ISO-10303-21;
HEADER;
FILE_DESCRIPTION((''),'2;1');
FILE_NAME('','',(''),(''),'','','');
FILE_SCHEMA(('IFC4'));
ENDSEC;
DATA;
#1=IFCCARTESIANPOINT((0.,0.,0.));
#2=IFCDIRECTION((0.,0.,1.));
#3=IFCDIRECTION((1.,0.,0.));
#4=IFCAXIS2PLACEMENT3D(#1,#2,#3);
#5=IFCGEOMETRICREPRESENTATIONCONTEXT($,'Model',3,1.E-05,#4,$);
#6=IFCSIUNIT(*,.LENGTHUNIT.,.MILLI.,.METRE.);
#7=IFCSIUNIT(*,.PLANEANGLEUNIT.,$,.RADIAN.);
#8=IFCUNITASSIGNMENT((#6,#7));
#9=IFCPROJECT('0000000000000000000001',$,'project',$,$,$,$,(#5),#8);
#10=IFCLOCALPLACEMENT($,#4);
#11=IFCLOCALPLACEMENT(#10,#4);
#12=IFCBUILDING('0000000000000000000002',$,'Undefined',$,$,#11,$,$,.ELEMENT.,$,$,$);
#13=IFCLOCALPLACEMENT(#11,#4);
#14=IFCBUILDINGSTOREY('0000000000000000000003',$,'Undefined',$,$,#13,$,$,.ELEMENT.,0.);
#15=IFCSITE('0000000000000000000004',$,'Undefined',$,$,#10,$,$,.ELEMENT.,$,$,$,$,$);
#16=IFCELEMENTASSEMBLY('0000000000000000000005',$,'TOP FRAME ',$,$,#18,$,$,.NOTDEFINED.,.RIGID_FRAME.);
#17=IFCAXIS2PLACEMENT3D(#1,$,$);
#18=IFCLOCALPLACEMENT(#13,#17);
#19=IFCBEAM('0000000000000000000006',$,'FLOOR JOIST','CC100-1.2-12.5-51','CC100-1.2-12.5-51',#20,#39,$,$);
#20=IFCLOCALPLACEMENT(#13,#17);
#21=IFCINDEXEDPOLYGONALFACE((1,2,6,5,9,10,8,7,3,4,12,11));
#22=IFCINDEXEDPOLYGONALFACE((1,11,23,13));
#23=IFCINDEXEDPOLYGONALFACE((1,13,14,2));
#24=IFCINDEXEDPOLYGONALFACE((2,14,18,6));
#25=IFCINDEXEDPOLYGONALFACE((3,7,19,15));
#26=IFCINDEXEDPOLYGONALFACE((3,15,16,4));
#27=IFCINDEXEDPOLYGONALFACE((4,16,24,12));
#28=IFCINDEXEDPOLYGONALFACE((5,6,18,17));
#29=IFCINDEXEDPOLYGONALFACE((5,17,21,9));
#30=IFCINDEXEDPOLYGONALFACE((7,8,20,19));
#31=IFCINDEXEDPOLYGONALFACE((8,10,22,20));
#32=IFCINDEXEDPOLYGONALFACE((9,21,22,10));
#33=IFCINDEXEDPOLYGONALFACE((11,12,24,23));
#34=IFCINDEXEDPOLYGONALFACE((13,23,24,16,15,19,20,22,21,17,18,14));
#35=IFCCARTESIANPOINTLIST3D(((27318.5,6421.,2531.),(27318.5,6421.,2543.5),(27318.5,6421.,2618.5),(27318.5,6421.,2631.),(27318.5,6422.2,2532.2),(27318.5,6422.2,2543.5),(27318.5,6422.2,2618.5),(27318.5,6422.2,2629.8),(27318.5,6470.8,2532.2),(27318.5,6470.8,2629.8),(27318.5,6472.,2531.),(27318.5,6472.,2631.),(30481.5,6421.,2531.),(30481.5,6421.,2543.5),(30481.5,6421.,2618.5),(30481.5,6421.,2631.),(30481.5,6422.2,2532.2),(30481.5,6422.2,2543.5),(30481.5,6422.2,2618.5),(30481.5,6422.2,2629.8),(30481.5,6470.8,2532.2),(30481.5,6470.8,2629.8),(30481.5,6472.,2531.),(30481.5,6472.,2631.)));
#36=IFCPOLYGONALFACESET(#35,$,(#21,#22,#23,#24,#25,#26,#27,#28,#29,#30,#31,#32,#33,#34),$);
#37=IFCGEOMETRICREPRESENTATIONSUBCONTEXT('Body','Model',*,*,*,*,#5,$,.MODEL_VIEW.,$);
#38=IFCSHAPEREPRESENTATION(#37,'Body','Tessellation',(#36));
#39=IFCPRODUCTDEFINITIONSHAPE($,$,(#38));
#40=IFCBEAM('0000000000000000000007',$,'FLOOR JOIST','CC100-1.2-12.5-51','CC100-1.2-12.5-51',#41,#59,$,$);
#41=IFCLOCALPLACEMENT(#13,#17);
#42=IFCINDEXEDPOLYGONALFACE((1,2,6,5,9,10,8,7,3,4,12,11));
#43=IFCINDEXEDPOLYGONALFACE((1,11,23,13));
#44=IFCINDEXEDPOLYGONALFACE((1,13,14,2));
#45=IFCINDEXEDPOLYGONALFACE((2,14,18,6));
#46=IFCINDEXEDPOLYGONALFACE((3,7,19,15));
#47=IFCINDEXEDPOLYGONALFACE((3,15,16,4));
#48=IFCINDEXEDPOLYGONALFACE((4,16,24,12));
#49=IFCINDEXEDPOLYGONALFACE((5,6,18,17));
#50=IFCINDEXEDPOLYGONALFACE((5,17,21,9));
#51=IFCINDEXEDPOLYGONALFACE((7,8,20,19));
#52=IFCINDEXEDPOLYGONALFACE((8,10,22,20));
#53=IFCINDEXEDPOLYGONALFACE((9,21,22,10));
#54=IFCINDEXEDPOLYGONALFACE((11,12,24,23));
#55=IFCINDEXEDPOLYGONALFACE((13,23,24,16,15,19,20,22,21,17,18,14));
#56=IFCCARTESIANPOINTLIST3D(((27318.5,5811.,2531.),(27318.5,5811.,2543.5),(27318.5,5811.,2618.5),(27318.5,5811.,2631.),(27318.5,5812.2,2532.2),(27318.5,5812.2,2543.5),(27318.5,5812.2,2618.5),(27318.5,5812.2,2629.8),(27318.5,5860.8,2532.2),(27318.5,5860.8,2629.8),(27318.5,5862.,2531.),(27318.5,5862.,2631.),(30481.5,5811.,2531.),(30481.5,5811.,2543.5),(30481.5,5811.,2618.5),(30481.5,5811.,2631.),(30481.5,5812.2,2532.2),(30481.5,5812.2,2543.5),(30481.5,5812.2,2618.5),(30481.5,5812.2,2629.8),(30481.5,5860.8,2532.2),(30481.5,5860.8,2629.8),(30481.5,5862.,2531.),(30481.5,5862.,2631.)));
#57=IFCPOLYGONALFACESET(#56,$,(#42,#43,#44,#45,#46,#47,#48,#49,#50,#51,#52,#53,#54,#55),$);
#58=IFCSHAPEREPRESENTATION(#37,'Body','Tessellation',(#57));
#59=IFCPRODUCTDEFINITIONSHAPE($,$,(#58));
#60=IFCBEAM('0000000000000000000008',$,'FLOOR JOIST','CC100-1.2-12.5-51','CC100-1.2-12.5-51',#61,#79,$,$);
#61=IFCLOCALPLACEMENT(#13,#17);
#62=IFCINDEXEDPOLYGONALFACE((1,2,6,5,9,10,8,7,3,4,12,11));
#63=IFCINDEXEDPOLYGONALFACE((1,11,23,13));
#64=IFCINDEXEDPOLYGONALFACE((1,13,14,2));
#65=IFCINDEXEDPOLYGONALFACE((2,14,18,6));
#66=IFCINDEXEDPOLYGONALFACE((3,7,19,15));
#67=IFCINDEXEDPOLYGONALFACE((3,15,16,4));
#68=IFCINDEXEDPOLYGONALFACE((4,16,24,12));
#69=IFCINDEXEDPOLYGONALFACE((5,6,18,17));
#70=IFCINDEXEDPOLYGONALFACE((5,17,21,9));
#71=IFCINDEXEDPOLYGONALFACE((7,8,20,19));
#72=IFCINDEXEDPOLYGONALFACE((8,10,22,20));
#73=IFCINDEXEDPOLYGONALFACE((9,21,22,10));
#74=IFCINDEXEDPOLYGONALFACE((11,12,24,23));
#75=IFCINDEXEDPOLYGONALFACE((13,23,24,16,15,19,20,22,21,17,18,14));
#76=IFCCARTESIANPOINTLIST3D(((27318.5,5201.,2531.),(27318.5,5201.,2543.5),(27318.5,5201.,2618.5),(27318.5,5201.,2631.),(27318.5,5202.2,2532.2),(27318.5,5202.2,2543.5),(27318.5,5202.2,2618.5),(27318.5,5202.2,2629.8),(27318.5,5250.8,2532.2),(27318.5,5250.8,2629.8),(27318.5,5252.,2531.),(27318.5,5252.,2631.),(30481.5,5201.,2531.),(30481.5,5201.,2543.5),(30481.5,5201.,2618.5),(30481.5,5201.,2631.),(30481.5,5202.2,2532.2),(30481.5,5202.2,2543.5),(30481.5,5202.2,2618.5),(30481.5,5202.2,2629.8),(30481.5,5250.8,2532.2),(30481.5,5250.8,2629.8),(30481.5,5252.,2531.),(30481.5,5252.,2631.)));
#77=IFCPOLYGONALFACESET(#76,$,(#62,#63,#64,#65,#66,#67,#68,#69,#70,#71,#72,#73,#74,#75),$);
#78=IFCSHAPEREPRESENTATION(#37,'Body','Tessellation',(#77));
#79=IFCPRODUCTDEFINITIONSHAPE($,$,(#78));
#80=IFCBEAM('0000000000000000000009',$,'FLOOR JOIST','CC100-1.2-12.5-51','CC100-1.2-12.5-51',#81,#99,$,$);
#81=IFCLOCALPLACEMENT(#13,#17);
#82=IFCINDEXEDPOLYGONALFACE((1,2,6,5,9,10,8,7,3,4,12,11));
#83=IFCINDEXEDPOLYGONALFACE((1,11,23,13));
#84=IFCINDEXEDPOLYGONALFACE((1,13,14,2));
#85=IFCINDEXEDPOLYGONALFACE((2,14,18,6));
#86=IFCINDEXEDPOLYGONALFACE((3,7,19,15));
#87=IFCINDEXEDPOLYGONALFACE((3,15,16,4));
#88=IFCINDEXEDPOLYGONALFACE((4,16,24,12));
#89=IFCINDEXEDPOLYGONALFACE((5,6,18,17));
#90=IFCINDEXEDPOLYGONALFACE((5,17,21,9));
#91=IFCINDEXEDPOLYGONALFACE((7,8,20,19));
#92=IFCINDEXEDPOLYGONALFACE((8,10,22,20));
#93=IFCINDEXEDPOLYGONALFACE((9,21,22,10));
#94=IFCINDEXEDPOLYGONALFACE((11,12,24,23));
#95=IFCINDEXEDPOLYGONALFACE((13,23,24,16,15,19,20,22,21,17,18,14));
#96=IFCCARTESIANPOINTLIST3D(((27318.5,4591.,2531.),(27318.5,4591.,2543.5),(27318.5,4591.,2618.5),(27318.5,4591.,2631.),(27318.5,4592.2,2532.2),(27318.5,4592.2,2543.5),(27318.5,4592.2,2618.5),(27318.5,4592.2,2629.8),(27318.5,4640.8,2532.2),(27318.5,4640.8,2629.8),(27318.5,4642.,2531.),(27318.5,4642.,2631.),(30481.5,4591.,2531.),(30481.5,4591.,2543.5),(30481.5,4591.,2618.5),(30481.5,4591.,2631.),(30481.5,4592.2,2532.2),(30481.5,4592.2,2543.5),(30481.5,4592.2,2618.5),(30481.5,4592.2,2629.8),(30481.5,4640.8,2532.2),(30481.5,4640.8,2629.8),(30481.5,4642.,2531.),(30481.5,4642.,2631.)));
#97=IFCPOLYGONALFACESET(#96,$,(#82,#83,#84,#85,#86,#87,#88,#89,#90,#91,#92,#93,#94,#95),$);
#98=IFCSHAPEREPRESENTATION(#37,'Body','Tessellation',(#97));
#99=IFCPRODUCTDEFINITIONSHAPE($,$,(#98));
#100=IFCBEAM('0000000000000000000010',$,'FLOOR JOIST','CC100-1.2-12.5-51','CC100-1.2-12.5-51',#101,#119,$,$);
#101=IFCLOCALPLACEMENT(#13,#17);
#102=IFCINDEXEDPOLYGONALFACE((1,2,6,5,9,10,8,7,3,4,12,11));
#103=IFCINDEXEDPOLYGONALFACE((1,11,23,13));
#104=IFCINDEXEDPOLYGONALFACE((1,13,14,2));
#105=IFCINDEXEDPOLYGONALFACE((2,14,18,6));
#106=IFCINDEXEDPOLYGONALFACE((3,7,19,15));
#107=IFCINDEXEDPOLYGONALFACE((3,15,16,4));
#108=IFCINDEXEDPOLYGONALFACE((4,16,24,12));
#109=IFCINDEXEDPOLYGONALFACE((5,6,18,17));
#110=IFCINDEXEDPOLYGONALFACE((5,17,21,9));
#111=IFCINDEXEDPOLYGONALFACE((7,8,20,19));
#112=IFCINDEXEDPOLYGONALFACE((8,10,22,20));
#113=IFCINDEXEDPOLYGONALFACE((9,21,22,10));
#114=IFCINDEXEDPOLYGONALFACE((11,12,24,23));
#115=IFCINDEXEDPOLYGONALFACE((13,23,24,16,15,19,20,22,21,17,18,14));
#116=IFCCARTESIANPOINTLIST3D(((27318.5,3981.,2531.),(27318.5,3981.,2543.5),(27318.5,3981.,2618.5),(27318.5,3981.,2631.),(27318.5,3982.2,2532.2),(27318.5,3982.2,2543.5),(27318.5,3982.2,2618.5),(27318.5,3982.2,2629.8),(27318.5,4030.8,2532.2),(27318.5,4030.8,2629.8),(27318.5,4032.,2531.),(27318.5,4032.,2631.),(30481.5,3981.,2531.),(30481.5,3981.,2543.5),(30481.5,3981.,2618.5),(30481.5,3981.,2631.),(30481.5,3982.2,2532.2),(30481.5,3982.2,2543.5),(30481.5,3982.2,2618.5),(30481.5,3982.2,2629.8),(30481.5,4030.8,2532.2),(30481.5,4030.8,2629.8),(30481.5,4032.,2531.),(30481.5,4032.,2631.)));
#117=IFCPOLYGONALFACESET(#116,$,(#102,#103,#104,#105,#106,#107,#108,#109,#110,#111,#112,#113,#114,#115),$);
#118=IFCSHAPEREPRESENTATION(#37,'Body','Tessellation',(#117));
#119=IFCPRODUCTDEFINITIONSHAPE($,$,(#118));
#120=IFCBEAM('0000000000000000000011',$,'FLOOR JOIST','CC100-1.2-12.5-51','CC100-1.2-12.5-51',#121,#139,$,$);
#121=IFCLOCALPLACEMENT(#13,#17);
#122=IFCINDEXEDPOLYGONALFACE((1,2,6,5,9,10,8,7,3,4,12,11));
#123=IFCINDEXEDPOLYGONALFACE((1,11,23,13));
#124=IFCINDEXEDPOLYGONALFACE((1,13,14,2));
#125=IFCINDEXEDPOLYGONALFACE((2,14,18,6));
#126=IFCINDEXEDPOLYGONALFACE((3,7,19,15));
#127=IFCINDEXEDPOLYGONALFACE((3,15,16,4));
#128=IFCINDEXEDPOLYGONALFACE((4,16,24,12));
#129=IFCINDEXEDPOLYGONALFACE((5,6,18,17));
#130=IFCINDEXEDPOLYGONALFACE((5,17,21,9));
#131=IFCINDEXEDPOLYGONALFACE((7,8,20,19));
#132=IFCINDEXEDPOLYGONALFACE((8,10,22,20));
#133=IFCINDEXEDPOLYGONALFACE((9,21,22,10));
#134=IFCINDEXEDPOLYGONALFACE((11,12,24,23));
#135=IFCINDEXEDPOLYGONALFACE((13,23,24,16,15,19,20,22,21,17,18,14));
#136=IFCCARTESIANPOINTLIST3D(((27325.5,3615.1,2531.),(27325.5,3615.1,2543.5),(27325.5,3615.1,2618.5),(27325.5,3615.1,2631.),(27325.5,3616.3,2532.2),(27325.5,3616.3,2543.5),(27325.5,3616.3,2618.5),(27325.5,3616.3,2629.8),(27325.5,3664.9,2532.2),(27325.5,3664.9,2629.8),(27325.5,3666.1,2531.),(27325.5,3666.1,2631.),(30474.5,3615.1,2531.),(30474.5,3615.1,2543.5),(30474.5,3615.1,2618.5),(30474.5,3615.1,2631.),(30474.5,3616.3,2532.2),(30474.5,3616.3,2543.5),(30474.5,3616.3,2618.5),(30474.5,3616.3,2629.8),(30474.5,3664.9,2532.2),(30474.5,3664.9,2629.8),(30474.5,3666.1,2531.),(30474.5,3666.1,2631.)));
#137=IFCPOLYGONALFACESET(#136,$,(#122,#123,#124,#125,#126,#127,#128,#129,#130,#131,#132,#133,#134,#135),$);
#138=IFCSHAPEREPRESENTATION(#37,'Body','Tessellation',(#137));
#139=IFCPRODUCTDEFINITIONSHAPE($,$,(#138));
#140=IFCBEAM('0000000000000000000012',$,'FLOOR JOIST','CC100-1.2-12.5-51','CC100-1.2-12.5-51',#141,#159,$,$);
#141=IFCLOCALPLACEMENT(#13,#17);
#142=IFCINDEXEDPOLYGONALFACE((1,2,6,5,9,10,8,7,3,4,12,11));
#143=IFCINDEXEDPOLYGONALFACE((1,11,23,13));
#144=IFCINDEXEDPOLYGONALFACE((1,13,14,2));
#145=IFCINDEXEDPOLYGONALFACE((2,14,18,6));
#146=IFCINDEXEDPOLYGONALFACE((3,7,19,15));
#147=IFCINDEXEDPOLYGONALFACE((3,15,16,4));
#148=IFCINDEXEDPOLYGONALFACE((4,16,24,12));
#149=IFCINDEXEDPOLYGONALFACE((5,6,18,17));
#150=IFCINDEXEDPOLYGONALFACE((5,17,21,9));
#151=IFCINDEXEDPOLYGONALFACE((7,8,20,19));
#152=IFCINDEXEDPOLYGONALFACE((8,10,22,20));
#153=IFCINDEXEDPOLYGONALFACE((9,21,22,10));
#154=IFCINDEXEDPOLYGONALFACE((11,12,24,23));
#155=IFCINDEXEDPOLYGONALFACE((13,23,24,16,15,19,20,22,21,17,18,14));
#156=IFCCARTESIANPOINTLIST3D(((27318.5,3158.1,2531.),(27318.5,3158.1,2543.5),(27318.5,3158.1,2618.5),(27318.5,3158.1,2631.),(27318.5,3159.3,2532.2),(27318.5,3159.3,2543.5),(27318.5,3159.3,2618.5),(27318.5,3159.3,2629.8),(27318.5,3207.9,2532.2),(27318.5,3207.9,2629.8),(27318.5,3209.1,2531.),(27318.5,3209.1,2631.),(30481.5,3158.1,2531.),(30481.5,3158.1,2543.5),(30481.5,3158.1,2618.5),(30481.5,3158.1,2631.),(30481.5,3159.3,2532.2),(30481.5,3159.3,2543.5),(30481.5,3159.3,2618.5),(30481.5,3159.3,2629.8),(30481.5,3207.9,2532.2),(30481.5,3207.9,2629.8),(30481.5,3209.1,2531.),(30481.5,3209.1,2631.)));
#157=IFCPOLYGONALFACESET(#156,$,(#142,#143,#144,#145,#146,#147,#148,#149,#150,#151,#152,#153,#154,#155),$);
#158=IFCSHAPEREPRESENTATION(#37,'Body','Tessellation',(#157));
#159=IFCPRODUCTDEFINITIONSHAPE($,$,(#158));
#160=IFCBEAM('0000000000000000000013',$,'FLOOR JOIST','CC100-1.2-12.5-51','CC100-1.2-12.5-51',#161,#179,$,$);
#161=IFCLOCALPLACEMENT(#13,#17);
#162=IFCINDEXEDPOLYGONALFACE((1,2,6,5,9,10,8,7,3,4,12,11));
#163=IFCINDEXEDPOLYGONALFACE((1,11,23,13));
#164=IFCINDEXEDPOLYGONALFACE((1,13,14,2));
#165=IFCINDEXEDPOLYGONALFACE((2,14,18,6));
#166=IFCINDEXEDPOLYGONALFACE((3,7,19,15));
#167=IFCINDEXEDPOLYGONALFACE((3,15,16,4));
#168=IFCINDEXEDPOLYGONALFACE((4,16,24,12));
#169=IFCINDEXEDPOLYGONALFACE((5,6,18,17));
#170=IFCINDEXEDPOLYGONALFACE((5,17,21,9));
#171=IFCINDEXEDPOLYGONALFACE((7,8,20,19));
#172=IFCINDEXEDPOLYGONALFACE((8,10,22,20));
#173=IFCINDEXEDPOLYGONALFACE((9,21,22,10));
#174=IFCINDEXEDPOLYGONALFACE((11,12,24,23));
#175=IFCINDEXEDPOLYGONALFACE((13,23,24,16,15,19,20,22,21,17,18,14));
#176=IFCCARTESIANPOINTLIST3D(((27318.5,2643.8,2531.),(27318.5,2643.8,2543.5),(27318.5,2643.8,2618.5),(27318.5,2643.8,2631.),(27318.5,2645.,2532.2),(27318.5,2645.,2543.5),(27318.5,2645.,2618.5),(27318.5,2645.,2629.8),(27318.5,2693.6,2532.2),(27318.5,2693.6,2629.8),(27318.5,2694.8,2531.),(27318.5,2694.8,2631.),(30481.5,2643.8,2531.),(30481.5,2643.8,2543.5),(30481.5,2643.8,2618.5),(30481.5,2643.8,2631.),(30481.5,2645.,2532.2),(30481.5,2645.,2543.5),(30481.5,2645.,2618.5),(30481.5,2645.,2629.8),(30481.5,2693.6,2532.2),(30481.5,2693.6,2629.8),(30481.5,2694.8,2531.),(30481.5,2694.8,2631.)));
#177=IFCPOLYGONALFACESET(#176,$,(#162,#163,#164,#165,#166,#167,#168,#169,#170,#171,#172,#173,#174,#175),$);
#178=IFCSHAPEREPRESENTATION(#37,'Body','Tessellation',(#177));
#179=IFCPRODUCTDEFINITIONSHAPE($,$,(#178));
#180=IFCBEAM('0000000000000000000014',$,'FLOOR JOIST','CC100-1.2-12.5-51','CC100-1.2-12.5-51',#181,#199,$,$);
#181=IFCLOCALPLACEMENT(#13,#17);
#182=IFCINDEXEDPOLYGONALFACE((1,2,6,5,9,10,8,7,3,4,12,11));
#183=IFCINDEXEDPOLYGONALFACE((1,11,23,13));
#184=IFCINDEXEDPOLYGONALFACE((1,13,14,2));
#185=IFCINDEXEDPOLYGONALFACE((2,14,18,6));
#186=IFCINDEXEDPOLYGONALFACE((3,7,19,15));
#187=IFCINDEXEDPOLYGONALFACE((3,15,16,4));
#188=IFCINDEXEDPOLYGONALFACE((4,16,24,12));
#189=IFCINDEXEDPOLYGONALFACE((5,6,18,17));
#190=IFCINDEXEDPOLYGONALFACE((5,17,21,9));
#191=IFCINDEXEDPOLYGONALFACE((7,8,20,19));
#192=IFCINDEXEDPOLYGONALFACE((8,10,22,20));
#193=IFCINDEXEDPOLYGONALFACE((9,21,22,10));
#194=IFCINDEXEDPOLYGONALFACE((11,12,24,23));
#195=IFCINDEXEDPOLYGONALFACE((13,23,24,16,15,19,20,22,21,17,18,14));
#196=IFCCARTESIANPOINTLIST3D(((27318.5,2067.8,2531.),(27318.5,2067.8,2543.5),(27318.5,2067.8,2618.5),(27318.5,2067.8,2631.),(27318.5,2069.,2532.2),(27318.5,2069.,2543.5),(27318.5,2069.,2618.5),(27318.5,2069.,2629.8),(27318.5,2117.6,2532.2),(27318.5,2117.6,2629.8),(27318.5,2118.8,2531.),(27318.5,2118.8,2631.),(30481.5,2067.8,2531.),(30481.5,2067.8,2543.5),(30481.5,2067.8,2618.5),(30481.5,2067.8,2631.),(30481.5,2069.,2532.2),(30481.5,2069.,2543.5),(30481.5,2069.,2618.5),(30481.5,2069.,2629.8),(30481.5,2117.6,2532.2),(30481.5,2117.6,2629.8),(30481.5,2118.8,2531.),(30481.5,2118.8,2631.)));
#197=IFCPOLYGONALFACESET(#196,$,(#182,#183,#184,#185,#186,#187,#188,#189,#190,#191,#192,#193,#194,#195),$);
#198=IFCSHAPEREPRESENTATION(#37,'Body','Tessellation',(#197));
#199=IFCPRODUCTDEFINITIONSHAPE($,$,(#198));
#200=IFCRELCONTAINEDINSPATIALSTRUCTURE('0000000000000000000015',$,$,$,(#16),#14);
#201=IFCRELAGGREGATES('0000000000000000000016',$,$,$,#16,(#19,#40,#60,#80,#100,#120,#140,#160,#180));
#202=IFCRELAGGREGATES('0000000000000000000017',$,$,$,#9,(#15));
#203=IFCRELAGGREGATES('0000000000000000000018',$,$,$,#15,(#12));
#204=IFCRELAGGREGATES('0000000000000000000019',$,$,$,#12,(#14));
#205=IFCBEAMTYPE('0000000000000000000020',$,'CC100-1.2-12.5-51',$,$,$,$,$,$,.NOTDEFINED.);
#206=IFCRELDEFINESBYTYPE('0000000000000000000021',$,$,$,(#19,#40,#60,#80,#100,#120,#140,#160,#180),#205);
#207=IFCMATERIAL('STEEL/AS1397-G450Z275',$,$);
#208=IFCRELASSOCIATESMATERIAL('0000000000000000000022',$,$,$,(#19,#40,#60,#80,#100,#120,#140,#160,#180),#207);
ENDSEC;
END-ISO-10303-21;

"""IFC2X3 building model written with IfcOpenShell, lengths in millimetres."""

from ifc_helpers import new_model, si_unit, frame, origin_with_axes, origin_2d_with_axis, place, context, subcontext, project, spatial, c_section, extrude, material, type_object, element, aggregate, save


model = new_model("IFC2X3")

# Units and contexts
model_context = context("Model", 3, precision=1e-05, world=origin_with_axes())
body_context = subcontext(model_context, "Body", "Model", "MODEL_VIEW")
ifc_project = project(units=[si_unit("LENGTHUNIT", "METRE", prefix="MILLI"), si_unit("PLANEANGLEUNIT", "RADIAN")], contexts=[model_context])

# Site, building, storey
site_placement = place(None, origin_with_axes())
site = spatial("IfcSite", under=ifc_project, at=site_placement, Name="Undefined", CompositionType="ELEMENT")
building_placement = place(site_placement, origin_with_axes())
building = spatial("IfcBuilding", under=site, at=building_placement, Name="Undefined", CompositionType="ELEMENT")
storey_placement = place(building_placement, origin_with_axes())
storey = spatial("IfcBuildingStorey", under=building, at=storey_placement, Name="Undefined", CompositionType="ELEMENT", Elevation=0.0)

# Element assembly, beams
assembly_1_placement = place(storey_placement, origin_with_axes())
assembly_1 = element("IfcElementAssembly", 1, at=assembly_1_placement, inside=storey, Name="TOP FRAME ", AssemblyPlace="NOTDEFINED", PredefinedType="RIGID_FRAME")
ifc_material_1 = material(Name="STEEL/AS1397-G450Z275")
beam_type_1 = type_object("IfcBeamType", Name="CC100-1.2-12.5-51", PredefinedType="NOTDEFINED")
beam_1_placement = place(assembly_1_placement, frame((27318.5, 6446.5, 2581.0), z_axis=(0.0, 0.0, 1.0), x_axis=(1.0, 0.0, 0.0)))
beam_1 = element("IfcBeam", 2, at=beam_1_placement, type_object=beam_type_1, material=ifc_material_1, Name="FLOOR JOIST", Description="CC100-1.2-12.5-51", ObjectType="CC100-1.2-12.5-51", context=body_context, shape_type="SweptSolid", body=[
    extrude(c_section(Depth=100.0, Width=51.0, WallThickness=1.2, Girth=12.5, at=origin_2d_with_axis()), frame((3163.0, 0.0, 0.0), z_axis=(-1.0, 0.0, 0.0), x_axis=(0.0, -1.0, 0.0)), (0.0, 0.0, 1.0), 3163.0),
])
beam_2_placement = place(assembly_1_placement, frame((27318.5, 5836.5, 2581.0), z_axis=(0.0, 0.0, 1.0), x_axis=(1.0, 0.0, 0.0)))
beam_2 = element("IfcBeam", 3, at=beam_2_placement, type_object=beam_type_1, material=ifc_material_1, Name="FLOOR JOIST", Description="CC100-1.2-12.5-51", ObjectType="CC100-1.2-12.5-51", context=body_context, shape_type="SweptSolid", body=[
    extrude(c_section(Depth=100.0, Width=51.0, WallThickness=1.2, Girth=12.5, at=origin_2d_with_axis()), frame((3163.0, 0.0, 0.0), z_axis=(-1.0, 0.0, 0.0), x_axis=(0.0, -1.0, 0.0)), (0.0, 0.0, 1.0), 3163.0),
])
beam_3_placement = place(assembly_1_placement, frame((27318.5, 5226.5, 2581.0), z_axis=(0.0, 0.0, 1.0), x_axis=(1.0, 0.0, 0.0)))
beam_3 = element("IfcBeam", 4, at=beam_3_placement, type_object=beam_type_1, material=ifc_material_1, Name="FLOOR JOIST", Description="CC100-1.2-12.5-51", ObjectType="CC100-1.2-12.5-51", context=body_context, shape_type="SweptSolid", body=[
    extrude(c_section(Depth=100.0, Width=51.0, WallThickness=1.2, Girth=12.5, at=origin_2d_with_axis()), frame((3163.0, 0.0, 0.0), z_axis=(-1.0, 0.0, 0.0), x_axis=(0.0, -1.0, 0.0)), (0.0, 0.0, 1.0), 3163.0),
])
beam_4_placement = place(assembly_1_placement, frame((27318.5, 4616.5, 2581.0), z_axis=(0.0, 0.0, 1.0), x_axis=(1.0, 0.0, 0.0)))
beam_4 = element("IfcBeam", 5, at=beam_4_placement, type_object=beam_type_1, material=ifc_material_1, Name="FLOOR JOIST", Description="CC100-1.2-12.5-51", ObjectType="CC100-1.2-12.5-51", context=body_context, shape_type="SweptSolid", body=[
    extrude(c_section(Depth=100.0, Width=51.0, WallThickness=1.2, Girth=12.5, at=origin_2d_with_axis()), frame((3163.0, 0.0, 0.0), z_axis=(-1.0, 0.0, 0.0), x_axis=(0.0, -1.0, 0.0)), (0.0, 0.0, 1.0), 3163.0),
])
beam_5_placement = place(assembly_1_placement, frame((27318.5, 4006.5, 2581.0), z_axis=(0.0, 0.0, 1.0), x_axis=(1.0, 0.0, 0.0)))
beam_5 = element("IfcBeam", 6, at=beam_5_placement, type_object=beam_type_1, material=ifc_material_1, Name="FLOOR JOIST", Description="CC100-1.2-12.5-51", ObjectType="CC100-1.2-12.5-51", context=body_context, shape_type="SweptSolid", body=[
    extrude(c_section(Depth=100.0, Width=51.0, WallThickness=1.2, Girth=12.5, at=origin_2d_with_axis()), frame((3163.0, 0.0, 0.0), z_axis=(-1.0, 0.0, 0.0), x_axis=(0.0, -1.0, 0.0)), (0.0, 0.0, 1.0), 3163.0),
])
beam_6_placement = place(assembly_1_placement, frame((27325.5, 3640.6, 2581.0), z_axis=(0.0, 0.0, 1.0), x_axis=(1.0, 0.0, 0.0)))
beam_6 = element("IfcBeam", 7, at=beam_6_placement, type_object=beam_type_1, material=ifc_material_1, Name="FLOOR JOIST", Description="CC100-1.2-12.5-51", ObjectType="CC100-1.2-12.5-51", context=body_context, shape_type="SweptSolid", body=[
    extrude(c_section(Depth=100.0, Width=51.0, WallThickness=1.2, Girth=12.5, at=origin_2d_with_axis()), frame((3149.0, 0.0, 0.0), z_axis=(-1.0, 0.0, 0.0), x_axis=(0.0, -1.0, 0.0)), (0.0, 0.0, 1.0), 3149.0),
])
beam_7_placement = place(assembly_1_placement, frame((27318.5, 3183.6, 2581.0), z_axis=(0.0, 0.0, 1.0), x_axis=(1.0, 0.0, 0.0)))
beam_7 = element("IfcBeam", 8, at=beam_7_placement, type_object=beam_type_1, material=ifc_material_1, Name="FLOOR JOIST", Description="CC100-1.2-12.5-51", ObjectType="CC100-1.2-12.5-51", context=body_context, shape_type="SweptSolid", body=[
    extrude(c_section(Depth=100.0, Width=51.0, WallThickness=1.2, Girth=12.5, at=origin_2d_with_axis()), frame((3163.0, 0.0, 0.0), z_axis=(-1.0, 0.0, 0.0), x_axis=(0.0, -1.0, 0.0)), (0.0, 0.0, 1.0), 3163.0),
])
beam_8_placement = place(assembly_1_placement, frame((27318.5, 2669.3, 2581.0), z_axis=(0.0, 0.0, 1.0), x_axis=(1.0, 0.0, 0.0)))
beam_8 = element("IfcBeam", 9, at=beam_8_placement, type_object=beam_type_1, material=ifc_material_1, Name="FLOOR JOIST", Description="CC100-1.2-12.5-51", ObjectType="CC100-1.2-12.5-51", context=body_context, shape_type="SweptSolid", body=[
    extrude(c_section(Depth=100.0, Width=51.0, WallThickness=1.2, Girth=12.5, at=origin_2d_with_axis()), frame((3163.0, 0.0, 0.0), z_axis=(-1.0, 0.0, 0.0), x_axis=(0.0, -1.0, 0.0)), (0.0, 0.0, 1.0), 3163.0),
])
beam_9_placement = place(assembly_1_placement, frame((27318.5, 2093.3, 2581.0), z_axis=(0.0, 0.0, 1.0), x_axis=(1.0, 0.0, 0.0)))
beam_9 = element("IfcBeam", 10, at=beam_9_placement, type_object=beam_type_1, material=ifc_material_1, Name="FLOOR JOIST", Description="CC100-1.2-12.5-51", ObjectType="CC100-1.2-12.5-51", context=body_context, shape_type="SweptSolid", body=[
    extrude(c_section(Depth=100.0, Width=51.0, WallThickness=1.2, Girth=12.5, at=origin_2d_with_axis()), frame((3163.0, 0.0, 0.0), z_axis=(-1.0, 0.0, 0.0), x_axis=(0.0, -1.0, 0.0)), (0.0, 0.0, 1.0), 3163.0),
])
aggregate(assembly_1, [beam_1, beam_2, beam_3, beam_4, beam_5, beam_6, beam_7, beam_8, beam_9])

save(model, "model.ifc")
